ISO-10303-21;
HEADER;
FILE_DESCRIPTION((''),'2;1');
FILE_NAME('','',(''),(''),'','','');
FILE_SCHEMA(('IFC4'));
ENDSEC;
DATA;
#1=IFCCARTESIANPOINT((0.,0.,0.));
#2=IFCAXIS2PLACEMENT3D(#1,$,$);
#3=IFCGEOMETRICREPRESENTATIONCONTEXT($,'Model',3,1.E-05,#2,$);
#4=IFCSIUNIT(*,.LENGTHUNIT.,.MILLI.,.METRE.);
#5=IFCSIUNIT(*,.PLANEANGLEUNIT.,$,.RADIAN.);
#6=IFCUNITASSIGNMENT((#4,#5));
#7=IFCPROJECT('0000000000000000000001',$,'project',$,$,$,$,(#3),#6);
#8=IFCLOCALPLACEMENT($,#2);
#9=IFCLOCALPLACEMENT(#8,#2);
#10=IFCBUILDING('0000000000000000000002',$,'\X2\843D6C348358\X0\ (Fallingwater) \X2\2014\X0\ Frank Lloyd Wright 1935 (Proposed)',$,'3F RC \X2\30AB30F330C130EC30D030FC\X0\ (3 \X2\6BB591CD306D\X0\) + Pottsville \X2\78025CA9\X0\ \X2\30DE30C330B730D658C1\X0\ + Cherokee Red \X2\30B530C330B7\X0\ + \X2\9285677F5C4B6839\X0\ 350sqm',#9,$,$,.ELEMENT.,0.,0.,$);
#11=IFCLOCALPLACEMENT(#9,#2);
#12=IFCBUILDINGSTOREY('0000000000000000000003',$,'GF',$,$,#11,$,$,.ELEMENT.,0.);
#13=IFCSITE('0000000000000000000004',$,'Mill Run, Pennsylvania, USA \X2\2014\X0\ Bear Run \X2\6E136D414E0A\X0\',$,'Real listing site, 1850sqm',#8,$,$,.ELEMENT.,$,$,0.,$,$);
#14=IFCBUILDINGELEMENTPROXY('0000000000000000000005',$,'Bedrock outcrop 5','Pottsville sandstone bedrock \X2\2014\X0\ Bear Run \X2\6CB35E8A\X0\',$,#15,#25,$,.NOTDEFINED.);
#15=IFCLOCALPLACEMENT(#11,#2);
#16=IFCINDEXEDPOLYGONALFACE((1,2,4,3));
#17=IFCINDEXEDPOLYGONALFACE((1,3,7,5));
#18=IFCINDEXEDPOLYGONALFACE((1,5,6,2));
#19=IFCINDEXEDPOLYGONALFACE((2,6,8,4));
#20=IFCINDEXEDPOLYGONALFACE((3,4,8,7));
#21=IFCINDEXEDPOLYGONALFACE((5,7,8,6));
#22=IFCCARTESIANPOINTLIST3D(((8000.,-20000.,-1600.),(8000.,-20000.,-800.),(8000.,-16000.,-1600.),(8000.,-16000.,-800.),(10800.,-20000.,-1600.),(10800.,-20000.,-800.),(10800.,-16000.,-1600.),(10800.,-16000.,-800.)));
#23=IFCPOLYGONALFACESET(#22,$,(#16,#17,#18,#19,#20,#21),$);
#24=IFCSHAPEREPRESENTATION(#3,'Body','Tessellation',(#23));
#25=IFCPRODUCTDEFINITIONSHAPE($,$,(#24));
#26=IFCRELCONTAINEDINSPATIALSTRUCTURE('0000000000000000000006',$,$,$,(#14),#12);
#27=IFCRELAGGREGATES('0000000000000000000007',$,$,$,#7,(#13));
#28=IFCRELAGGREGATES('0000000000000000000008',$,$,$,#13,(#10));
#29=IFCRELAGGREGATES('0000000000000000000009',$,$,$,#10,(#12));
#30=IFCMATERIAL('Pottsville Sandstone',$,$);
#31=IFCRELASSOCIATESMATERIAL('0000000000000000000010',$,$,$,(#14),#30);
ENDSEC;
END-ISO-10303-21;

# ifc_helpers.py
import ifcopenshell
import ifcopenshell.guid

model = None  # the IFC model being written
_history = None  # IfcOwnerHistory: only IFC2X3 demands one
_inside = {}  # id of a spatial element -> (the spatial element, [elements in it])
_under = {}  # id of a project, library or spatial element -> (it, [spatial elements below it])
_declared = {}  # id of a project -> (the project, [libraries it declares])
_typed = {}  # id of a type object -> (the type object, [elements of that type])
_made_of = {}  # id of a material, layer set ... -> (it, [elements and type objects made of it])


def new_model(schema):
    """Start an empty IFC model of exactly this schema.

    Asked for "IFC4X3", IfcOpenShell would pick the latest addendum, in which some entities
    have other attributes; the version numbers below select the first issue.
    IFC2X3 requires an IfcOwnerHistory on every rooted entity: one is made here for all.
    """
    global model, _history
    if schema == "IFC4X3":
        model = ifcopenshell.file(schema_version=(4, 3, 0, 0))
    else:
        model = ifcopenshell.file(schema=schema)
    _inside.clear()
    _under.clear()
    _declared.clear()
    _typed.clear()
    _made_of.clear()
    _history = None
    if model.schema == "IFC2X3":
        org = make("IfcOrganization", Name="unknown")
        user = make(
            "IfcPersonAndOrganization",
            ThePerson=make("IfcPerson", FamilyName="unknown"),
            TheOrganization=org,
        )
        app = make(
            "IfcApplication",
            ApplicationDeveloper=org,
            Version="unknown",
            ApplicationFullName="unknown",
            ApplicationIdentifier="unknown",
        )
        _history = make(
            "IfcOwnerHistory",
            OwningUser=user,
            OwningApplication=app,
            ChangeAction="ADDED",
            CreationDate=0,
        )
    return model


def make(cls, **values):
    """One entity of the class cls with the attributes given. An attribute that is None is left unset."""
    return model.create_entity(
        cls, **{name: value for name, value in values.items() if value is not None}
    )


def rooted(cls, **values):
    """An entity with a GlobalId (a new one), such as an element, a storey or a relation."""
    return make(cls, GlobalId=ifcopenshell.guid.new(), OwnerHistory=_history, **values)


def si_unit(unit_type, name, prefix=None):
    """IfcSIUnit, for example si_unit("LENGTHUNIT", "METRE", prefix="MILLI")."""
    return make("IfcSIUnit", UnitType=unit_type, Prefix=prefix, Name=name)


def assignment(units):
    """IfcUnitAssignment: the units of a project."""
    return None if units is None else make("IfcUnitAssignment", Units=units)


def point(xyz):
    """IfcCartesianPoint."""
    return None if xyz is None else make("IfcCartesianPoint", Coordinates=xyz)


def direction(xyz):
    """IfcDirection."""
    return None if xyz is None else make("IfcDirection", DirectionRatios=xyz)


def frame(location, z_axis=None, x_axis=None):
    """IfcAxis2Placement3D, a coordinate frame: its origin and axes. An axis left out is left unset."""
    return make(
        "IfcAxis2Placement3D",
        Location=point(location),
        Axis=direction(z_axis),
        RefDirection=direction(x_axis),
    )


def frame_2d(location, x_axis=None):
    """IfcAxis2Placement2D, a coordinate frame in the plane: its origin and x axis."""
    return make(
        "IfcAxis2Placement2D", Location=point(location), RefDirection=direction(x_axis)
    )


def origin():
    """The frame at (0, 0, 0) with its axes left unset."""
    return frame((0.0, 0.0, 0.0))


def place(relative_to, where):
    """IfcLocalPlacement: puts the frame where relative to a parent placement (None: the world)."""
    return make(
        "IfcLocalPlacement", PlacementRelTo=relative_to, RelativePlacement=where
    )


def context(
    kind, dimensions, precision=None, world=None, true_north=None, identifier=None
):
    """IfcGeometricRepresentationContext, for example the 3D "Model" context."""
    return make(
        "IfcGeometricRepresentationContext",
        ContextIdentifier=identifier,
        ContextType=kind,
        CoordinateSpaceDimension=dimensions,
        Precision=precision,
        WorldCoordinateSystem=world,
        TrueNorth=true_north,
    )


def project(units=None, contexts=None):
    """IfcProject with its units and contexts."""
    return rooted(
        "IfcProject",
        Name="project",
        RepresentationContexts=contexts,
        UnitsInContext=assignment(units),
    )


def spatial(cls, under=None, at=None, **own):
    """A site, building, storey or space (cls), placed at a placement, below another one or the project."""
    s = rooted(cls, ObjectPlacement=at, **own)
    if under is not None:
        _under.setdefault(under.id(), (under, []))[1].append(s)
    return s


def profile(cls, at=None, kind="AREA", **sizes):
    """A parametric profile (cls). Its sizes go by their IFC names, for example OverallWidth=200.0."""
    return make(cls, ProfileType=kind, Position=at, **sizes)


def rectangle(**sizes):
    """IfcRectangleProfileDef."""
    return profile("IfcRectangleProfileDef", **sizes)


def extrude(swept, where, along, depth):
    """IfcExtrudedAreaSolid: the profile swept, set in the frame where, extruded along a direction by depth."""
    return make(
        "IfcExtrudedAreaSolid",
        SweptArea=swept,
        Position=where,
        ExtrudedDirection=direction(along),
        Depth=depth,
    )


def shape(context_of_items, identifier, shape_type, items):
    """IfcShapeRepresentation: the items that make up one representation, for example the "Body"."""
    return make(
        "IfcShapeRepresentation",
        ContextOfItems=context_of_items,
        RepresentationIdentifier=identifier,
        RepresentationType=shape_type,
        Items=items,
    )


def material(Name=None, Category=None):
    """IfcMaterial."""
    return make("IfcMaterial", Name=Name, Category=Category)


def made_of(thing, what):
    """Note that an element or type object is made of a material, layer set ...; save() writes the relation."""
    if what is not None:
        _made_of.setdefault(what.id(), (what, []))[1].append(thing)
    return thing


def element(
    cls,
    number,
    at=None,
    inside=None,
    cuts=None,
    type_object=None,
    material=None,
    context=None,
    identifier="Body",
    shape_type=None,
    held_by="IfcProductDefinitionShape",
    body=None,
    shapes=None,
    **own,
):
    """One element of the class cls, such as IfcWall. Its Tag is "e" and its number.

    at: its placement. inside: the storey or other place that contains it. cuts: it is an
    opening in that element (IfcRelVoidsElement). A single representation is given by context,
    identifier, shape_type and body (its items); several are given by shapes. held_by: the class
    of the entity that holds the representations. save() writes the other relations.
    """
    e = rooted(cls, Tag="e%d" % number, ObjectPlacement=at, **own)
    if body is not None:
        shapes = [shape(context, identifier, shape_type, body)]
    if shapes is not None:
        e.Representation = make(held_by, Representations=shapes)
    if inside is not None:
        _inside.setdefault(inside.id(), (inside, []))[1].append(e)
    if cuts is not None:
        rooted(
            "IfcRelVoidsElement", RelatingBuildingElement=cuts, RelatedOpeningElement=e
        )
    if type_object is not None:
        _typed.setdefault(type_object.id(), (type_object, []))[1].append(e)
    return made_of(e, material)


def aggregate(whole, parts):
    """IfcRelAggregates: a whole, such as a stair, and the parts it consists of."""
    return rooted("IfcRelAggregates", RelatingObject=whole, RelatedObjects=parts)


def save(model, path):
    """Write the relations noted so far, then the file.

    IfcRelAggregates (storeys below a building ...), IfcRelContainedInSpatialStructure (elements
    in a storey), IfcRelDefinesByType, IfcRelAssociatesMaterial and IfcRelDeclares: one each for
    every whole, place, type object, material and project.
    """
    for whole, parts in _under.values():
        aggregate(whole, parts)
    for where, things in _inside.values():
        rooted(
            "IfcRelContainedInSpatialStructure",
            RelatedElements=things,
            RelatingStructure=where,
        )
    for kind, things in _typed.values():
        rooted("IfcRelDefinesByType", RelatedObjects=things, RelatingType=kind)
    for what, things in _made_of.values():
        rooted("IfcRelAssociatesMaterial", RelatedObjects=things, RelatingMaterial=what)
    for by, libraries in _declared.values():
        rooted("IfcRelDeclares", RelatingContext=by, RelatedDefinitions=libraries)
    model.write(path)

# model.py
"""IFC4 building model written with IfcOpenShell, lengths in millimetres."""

from ifc_helpers import new_model, si_unit, frame, frame_2d, origin, place, context, project, spatial, rectangle, extrude, material, element, save


model = new_model("IFC4")

# Units and contexts
model_context = context("Model", 3, precision=1e-05, world=origin())
ifc_project = project(units=[si_unit("LENGTHUNIT", "METRE", prefix="MILLI"), si_unit("PLANEANGLEUNIT", "RADIAN")], contexts=[model_context])

# Site, building, storey
site_placement = place(None, origin())
site = spatial("IfcSite", under=ifc_project, at=site_placement, Name="Mill Run, Pennsylvania, USA — Bear Run 渓流上", ObjectType="Real listing site, 1850sqm", CompositionType="ELEMENT", RefElevation=0.0)
building_placement = place(site_placement, origin())
building = spatial("IfcBuilding", under=site, at=building_placement, Name="落水荘 (Fallingwater) — Frank Lloyd Wright 1935 (Proposed)", ObjectType="3F RC カンチレバー (3 段重ね) + Pottsville 砂岩 マッシブ壁 + Cherokee Red サッシ + 銅板屋根 350sqm", CompositionType="ELEMENT", ElevationOfRefHeight=0.0, ElevationOfTerrain=0.0)
storey_placement = place(building_placement, origin())
storey = spatial("IfcBuildingStorey", under=building, at=storey_placement, Name="GF", CompositionType="ELEMENT", Elevation=0.0)

# Building element proxy
ifc_material_1 = material(Name="Pottsville Sandstone")
proxy_1_placement = place(storey_placement, frame((4000.0, -10000.0, -800.0)))
element("IfcBuildingElementProxy", 1, at=proxy_1_placement, inside=storey, material=ifc_material_1, Name="Bedrock outcrop 5", Description="Pottsville sandstone bedrock — Bear Run 河床", PredefinedType="NOTDEFINED", context=model_context, shape_type="SweptSolid", body=[
    extrude(rectangle(XDim=2800.0, YDim=4000.0, at=frame_2d((1400.0, 2000.0))), frame((4000.0, -10000.0, -800.0)), (0.0, 0.0, 1.0), 800.0),
])

save(model, "model.ifc")
